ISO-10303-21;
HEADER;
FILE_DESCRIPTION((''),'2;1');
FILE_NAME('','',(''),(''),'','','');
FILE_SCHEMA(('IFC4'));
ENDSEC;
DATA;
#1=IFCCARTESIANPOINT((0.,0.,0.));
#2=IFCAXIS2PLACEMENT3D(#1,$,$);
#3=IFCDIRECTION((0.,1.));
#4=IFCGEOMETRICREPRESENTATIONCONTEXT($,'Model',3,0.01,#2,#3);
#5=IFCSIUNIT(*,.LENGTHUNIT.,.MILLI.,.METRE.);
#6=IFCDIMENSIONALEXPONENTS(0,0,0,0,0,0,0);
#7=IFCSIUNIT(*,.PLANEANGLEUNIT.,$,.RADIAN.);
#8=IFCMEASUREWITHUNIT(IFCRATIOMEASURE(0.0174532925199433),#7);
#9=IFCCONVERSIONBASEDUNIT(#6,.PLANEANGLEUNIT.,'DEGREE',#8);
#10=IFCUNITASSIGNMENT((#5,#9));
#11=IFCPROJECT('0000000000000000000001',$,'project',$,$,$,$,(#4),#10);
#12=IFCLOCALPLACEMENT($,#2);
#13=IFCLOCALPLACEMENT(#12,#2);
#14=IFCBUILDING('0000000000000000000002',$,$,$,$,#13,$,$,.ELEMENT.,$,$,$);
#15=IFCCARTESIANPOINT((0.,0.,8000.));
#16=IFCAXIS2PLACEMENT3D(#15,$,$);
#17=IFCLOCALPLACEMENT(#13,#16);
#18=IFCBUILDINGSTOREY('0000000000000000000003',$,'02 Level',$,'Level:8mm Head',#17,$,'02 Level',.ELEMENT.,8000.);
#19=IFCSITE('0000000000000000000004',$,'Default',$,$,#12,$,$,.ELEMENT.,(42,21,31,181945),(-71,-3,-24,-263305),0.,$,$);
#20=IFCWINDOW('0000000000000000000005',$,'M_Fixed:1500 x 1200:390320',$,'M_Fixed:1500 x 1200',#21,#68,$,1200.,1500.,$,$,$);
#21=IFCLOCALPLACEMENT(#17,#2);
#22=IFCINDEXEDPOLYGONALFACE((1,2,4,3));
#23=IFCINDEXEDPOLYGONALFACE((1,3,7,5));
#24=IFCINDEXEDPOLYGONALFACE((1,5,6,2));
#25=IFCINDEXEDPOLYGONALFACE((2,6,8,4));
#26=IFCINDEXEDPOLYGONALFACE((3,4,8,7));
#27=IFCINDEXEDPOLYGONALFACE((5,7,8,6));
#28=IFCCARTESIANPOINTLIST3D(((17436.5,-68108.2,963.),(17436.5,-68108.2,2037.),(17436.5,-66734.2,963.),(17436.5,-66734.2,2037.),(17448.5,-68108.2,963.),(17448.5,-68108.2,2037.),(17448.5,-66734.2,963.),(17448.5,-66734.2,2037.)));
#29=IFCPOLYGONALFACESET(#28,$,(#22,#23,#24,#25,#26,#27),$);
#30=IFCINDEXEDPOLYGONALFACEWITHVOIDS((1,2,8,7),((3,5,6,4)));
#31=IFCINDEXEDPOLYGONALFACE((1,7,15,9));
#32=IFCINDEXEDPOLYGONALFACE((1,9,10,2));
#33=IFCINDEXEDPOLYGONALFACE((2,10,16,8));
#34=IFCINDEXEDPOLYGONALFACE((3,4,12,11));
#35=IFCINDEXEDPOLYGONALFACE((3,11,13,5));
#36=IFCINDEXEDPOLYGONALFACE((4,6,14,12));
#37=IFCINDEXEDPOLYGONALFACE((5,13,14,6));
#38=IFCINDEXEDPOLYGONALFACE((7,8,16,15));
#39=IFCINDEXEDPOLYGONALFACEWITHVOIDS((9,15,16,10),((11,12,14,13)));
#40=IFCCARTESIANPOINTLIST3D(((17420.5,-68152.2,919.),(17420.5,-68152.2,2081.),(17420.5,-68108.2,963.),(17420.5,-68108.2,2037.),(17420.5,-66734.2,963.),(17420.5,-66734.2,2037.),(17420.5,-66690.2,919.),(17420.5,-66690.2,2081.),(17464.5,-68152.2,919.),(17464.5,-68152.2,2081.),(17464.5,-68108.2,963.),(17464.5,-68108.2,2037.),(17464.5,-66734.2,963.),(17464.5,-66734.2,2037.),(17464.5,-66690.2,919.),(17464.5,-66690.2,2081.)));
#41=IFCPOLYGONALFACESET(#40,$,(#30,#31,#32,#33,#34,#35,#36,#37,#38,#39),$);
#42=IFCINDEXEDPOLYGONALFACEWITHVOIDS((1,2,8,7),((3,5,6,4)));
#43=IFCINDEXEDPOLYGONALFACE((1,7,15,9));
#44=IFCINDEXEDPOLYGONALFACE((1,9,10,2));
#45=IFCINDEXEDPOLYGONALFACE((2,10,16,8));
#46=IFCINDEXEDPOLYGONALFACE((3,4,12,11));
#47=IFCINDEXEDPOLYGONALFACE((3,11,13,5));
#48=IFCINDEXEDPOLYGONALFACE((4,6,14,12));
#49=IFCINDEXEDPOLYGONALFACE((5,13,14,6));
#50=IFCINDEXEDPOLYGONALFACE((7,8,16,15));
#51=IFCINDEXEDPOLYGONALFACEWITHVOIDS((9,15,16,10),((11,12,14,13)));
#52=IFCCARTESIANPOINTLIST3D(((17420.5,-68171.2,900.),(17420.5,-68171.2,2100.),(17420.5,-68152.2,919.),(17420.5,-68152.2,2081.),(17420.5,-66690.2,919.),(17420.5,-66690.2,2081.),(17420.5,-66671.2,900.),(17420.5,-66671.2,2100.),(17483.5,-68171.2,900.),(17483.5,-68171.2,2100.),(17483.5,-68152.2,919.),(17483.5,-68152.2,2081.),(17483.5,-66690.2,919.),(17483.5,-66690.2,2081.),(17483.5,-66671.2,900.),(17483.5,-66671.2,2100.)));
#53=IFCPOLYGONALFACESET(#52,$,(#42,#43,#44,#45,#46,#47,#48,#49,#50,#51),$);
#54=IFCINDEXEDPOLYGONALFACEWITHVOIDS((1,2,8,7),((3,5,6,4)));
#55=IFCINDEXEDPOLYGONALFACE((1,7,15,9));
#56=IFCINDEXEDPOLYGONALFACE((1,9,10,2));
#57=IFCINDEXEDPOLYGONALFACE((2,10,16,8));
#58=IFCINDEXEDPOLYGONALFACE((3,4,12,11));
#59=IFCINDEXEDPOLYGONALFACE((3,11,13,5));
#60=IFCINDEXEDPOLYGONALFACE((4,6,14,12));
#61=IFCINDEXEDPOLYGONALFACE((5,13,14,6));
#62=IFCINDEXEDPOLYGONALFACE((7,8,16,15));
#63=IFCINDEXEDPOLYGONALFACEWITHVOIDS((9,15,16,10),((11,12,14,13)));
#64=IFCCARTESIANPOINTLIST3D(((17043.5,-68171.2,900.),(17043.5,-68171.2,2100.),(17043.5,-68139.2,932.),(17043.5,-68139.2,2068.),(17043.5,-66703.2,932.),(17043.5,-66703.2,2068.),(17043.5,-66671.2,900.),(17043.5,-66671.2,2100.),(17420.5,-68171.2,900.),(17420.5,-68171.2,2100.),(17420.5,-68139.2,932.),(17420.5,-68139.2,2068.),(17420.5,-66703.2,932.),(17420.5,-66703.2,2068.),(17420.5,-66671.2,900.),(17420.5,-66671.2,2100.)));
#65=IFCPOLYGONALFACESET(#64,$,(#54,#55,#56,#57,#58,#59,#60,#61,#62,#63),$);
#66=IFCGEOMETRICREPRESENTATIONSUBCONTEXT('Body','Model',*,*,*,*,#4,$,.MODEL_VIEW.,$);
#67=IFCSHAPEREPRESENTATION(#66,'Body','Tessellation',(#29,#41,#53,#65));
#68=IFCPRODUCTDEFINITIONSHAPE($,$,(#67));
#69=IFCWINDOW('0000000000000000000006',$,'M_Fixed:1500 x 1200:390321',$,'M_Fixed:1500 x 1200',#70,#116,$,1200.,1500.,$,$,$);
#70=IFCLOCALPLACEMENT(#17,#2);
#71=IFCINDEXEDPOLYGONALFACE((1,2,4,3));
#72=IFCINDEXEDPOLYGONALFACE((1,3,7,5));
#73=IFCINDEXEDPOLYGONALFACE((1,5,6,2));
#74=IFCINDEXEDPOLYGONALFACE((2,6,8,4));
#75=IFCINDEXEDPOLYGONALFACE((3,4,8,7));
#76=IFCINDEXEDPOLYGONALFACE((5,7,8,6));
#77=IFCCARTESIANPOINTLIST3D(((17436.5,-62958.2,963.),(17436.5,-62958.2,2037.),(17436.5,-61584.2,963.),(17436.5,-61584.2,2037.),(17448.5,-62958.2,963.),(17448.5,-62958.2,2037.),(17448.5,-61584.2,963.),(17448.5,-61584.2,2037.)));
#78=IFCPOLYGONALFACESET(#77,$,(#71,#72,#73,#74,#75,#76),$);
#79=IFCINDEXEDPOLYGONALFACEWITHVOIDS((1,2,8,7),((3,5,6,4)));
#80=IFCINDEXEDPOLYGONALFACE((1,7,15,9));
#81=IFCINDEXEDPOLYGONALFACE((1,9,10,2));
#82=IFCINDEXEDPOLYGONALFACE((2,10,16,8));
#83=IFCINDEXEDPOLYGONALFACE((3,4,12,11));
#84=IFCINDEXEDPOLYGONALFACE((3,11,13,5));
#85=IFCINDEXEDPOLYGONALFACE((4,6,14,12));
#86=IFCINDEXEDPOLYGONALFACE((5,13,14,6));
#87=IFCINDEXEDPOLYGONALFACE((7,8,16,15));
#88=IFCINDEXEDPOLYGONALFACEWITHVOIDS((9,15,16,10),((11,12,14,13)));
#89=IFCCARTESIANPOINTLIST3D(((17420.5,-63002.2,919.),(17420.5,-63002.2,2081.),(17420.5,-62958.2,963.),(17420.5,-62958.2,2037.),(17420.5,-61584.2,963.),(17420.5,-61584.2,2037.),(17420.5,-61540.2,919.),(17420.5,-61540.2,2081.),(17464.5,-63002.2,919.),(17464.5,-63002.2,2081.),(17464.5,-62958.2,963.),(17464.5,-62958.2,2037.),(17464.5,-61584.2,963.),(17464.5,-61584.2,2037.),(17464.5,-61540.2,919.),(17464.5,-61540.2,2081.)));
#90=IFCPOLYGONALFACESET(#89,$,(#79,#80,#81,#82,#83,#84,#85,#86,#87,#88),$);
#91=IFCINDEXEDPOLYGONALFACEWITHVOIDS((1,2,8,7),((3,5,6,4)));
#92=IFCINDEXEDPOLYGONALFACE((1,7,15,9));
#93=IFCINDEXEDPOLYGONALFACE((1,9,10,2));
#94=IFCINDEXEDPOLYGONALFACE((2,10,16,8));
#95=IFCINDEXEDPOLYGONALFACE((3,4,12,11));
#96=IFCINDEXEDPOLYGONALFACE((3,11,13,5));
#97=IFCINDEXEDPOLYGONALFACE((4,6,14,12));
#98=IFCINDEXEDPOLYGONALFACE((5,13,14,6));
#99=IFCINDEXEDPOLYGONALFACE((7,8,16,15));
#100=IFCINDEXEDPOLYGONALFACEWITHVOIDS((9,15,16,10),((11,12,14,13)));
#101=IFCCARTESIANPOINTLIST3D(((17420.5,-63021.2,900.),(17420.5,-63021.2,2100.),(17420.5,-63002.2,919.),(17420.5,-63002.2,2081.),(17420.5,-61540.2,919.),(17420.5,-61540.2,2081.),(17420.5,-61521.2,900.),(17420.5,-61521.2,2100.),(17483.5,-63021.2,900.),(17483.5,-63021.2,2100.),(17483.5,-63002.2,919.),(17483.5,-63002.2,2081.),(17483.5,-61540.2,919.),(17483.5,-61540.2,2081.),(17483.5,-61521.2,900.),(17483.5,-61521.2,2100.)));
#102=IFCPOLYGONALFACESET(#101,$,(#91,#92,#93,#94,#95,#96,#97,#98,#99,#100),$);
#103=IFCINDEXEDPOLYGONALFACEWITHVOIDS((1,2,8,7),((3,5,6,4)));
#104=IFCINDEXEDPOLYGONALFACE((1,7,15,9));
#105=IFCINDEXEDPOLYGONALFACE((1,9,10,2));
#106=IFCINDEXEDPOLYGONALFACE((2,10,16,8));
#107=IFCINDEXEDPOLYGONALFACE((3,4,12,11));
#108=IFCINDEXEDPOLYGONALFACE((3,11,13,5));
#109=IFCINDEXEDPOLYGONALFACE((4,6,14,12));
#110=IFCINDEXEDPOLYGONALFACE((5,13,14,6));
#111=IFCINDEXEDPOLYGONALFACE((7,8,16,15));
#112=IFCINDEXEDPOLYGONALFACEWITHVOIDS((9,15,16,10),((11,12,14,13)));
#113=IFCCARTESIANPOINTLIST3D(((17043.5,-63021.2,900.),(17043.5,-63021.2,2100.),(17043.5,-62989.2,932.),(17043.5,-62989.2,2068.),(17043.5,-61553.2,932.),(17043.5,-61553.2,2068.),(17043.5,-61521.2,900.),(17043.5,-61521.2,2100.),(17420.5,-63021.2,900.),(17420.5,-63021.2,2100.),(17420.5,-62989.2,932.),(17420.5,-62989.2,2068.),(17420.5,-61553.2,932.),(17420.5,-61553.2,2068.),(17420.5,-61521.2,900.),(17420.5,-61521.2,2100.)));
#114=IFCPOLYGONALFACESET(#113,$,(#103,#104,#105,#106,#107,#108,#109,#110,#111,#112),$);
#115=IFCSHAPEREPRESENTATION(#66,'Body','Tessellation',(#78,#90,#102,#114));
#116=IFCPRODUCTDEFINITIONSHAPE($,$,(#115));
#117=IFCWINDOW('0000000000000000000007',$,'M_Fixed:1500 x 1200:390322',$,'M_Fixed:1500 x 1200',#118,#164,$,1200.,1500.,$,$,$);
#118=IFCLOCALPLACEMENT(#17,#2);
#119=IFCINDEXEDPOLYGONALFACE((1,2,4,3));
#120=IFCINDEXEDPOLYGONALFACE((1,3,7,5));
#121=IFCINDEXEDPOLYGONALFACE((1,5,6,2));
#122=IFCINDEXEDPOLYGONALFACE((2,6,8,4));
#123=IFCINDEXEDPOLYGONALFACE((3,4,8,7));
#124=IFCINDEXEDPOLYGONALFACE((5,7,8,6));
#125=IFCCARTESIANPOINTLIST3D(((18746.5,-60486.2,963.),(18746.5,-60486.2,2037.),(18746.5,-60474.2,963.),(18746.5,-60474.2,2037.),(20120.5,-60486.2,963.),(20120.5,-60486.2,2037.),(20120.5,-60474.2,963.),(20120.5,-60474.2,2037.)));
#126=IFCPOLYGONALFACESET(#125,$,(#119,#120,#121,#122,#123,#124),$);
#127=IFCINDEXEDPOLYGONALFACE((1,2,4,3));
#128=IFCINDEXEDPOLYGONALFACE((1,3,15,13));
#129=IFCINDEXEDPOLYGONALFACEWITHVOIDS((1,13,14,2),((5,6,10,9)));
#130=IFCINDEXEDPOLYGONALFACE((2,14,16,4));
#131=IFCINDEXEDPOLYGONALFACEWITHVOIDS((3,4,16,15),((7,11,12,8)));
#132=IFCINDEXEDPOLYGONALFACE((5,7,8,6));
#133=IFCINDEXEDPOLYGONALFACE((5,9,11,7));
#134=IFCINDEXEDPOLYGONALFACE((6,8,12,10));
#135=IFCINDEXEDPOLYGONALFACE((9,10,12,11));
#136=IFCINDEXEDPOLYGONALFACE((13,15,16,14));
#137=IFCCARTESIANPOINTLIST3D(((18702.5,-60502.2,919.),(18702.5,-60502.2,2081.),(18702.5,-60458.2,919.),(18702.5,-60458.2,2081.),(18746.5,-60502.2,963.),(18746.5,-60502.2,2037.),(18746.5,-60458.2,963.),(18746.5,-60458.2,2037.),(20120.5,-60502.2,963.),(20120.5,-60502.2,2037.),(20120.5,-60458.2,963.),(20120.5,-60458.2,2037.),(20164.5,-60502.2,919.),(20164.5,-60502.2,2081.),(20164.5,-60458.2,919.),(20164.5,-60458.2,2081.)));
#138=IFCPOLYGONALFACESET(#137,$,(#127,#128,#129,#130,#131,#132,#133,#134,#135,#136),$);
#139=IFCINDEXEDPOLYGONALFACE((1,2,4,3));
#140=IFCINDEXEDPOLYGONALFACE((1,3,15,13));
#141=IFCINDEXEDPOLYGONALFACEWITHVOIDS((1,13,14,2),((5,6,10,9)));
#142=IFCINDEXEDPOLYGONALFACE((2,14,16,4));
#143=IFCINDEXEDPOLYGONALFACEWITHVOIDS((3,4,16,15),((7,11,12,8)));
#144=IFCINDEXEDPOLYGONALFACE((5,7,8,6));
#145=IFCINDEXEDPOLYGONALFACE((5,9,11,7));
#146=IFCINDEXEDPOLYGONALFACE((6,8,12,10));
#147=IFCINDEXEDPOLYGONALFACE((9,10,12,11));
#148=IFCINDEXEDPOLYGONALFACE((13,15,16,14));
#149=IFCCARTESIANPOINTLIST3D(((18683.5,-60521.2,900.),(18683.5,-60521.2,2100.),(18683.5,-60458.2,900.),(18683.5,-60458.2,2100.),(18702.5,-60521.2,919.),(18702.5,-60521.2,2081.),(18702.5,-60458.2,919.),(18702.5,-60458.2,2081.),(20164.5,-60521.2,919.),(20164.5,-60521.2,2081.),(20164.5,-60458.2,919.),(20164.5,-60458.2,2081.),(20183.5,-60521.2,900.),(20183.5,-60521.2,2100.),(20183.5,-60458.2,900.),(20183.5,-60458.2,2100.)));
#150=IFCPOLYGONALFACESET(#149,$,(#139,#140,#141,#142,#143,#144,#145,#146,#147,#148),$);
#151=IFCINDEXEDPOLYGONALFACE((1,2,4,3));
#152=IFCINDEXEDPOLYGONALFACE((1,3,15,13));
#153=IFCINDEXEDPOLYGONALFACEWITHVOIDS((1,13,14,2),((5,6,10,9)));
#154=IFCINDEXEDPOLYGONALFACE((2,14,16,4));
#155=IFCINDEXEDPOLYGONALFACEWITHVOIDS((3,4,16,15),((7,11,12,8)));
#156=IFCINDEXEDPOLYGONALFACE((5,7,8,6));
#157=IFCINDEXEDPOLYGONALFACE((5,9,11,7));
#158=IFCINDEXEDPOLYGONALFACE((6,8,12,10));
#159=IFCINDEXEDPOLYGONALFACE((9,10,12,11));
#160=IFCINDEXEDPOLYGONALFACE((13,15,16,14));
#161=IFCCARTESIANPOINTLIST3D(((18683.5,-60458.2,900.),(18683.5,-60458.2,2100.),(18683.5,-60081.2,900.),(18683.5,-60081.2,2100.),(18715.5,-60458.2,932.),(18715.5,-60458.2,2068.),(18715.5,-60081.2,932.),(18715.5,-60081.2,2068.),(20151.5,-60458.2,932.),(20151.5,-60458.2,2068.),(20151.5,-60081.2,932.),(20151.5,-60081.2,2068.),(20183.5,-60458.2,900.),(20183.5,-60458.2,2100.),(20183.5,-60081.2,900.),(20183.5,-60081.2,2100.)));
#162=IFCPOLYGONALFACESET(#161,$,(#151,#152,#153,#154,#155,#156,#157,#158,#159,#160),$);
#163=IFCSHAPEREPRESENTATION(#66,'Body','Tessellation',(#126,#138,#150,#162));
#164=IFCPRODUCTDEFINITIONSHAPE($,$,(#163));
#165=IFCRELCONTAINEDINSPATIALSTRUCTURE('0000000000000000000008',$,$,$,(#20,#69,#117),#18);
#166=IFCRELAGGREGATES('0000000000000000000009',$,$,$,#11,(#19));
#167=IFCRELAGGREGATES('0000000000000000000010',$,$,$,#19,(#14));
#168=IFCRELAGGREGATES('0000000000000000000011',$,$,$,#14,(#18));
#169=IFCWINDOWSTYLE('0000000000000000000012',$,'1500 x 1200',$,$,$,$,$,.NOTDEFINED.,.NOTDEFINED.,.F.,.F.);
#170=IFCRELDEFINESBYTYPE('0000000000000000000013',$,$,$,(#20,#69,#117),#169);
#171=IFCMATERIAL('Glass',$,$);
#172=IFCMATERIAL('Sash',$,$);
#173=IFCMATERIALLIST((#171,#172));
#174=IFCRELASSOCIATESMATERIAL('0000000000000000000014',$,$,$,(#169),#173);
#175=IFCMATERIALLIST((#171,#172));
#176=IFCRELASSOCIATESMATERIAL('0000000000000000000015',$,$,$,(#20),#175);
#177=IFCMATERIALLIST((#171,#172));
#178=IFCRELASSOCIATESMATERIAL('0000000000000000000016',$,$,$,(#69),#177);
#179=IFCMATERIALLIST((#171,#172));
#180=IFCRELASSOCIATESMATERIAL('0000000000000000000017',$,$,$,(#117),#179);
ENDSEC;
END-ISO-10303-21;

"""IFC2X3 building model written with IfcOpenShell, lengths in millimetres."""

from ifc_helpers import new_model, entity, si_unit, converted_unit, direction, frame, origin, origin_2d_with_axis, place, context, subcontext, project, spatial, polyline, rectangle, outline, extrude, source, transform, mapped, material, material_list, type_object, type_shapes, element, save


model = new_model("IFC2X3")

# Units and contexts
model_context = context("Model", 3, precision=0.01, world=origin(), true_north=direction((0.0, 1.0)))
body_context = subcontext(model_context, "Body", "Model", "MODEL_VIEW")
ifc_project = project(units=[si_unit("LENGTHUNIT", "METRE", prefix="MILLI"), converted_unit("PLANEANGLEUNIT", "DEGREE", entity("IfcRatioMeasure", 0.0174532925199433), si_unit("PLANEANGLEUNIT", "RADIAN"), dimensions=[0, 0, 0, 0, 0, 0, 0])], contexts=[model_context])

# Site, building, storey
site_placement = place(None, origin())
site = spatial("IfcSite", under=ifc_project, at=site_placement, Name="Default", CompositionType="ELEMENT", RefLatitude=(42, 21, 31, 181945), RefLongitude=(-71, -3, -24, -263305), RefElevation=0.0)
building_placement = place(site_placement, origin())
building = spatial("IfcBuilding", under=site, at=building_placement, CompositionType="ELEMENT")
storey_placement = place(building_placement, frame((0.0, 0.0, 8000.0)))
storey = spatial("IfcBuildingStorey", under=building, at=storey_placement, Name="02 Level", ObjectType="Level:8mm Head", LongName="02 Level", CompositionType="ELEMENT", Elevation=8000.0)

# Windows
ifc_material_1 = material(Name="Glass")
ifc_material_2 = material(Name="Sash")
ifc_material_list_1 = material_list([ifc_material_1, ifc_material_2])
ifc_material_list_2 = material_list([ifc_material_1, ifc_material_2])
window_style_1 = type_object("IfcWindowStyle", Name="1500 x 1200", ConstructionType="NOTDEFINED", OperationType="NOTDEFINED", ParameterTakesPrecedence=False, Sizeable=False, material=ifc_material_list_2)
shared_shape_1 = source(origin(), body_context, "Body", "SweptSolid", [
    extrude(rectangle(XDim=1374.0, YDim=12.0, at=origin_2d_with_axis()), frame((750.0, 425.0, 63.0), z_axis=(0.0, 0.0, 1.0), x_axis=(-1.0, 0.0, 0.0)), (0.0, 0.0, 1.0), 1074.0),
    extrude(outline(polyline([(-731.0, -581.0), (731.0, -581.0), (731.0, 581.0), (-731.0, 581.0), (-731.0, -581.0)]), holes=[polyline([(-687.0, -537.0), (-687.0, 537.0), (687.0, 537.0), (687.0, -537.0), (-687.0, -537.0)])]), frame((750.0, 447.0, 600.0), z_axis=(0.0, -1.0, 0.0), x_axis=(-1.0, 0.0, 0.0)), (0.0, 0.0, 1.0), 44.0),
    extrude(outline(polyline([(-750.0, -600.0), (750.0, -600.0), (750.0, 600.0), (-750.0, 600.0), (-750.0, -600.0)]), holes=[polyline([(-731.0, -581.0), (-731.0, 581.0), (731.0, 581.0), (731.0, -581.0), (-731.0, -581.0)])]), frame((750.0, 466.0, 600.0), z_axis=(0.0, -1.0, 0.0), x_axis=(-1.0, 0.0, 0.0)), (0.0, 0.0, 1.0), 63.0),
    extrude(outline(polyline([(-750.0, -600.0), (750.0, -600.0), (750.0, 600.0), (-750.0, 600.0), (-750.0, -600.0)]), holes=[polyline([(-718.0, -568.0), (-718.0, 568.0), (718.0, 568.0), (718.0, -568.0), (-718.0, -568.0)])]), frame((750.0, 403.0, 600.0), z_axis=(0.0, -1.0, 0.0), x_axis=(-1.0, 0.0, 0.0)), (0.0, 0.0, 1.0), 377.0),
])
type_shapes(window_style_1, [shared_shape_1])
window_1_placement = place(storey_placement, frame((17017.5, -66671.2, 900.0), z_axis=(0.0, 0.0, 1.0), x_axis=(0.0, -1.0, 0.0)))
element("IfcWindow", 1, at=window_1_placement, inside=storey, type_object=window_style_1, material=ifc_material_list_1, Name="M_Fixed:1500 x 1200:390320", ObjectType="M_Fixed:1500 x 1200", OverallHeight=1200.0, OverallWidth=1500.0, context=body_context, shape_type="MappedRepresentation", body=[
    mapped(shared_shape_1, transform((0.0, 0.0, 0.0), scale=1.0)),
])
ifc_material_list_3 = material_list([ifc_material_1, ifc_material_2])
window_2_placement = place(storey_placement, frame((17017.5, -61521.2, 900.0), z_axis=(0.0, 0.0, 1.0), x_axis=(0.0, -1.0, 0.0)))
element("IfcWindow", 2, at=window_2_placement, inside=storey, type_object=window_style_1, material=ifc_material_list_3, Name="M_Fixed:1500 x 1200:390321", ObjectType="M_Fixed:1500 x 1200", OverallHeight=1200.0, OverallWidth=1500.0, context=body_context, shape_type="MappedRepresentation", body=[
    mapped(shared_shape_1, transform((0.0, 0.0, 0.0), scale=1.0)),
])
ifc_material_list_4 = material_list([ifc_material_1, ifc_material_2])
window_3_placement = place(storey_placement, frame((20183.5, -60055.2, 900.0), z_axis=(0.0, 0.0, 1.0), x_axis=(-1.0, 0.0, 0.0)))
element("IfcWindow", 3, at=window_3_placement, inside=storey, type_object=window_style_1, material=ifc_material_list_4, Name="M_Fixed:1500 x 1200:390322", ObjectType="M_Fixed:1500 x 1200", OverallHeight=1200.0, OverallWidth=1500.0, context=body_context, shape_type="MappedRepresentation", body=[
    mapped(shared_shape_1, transform((0.0, 0.0, 0.0), scale=1.0)),
])

save(model, "model.ifc")
